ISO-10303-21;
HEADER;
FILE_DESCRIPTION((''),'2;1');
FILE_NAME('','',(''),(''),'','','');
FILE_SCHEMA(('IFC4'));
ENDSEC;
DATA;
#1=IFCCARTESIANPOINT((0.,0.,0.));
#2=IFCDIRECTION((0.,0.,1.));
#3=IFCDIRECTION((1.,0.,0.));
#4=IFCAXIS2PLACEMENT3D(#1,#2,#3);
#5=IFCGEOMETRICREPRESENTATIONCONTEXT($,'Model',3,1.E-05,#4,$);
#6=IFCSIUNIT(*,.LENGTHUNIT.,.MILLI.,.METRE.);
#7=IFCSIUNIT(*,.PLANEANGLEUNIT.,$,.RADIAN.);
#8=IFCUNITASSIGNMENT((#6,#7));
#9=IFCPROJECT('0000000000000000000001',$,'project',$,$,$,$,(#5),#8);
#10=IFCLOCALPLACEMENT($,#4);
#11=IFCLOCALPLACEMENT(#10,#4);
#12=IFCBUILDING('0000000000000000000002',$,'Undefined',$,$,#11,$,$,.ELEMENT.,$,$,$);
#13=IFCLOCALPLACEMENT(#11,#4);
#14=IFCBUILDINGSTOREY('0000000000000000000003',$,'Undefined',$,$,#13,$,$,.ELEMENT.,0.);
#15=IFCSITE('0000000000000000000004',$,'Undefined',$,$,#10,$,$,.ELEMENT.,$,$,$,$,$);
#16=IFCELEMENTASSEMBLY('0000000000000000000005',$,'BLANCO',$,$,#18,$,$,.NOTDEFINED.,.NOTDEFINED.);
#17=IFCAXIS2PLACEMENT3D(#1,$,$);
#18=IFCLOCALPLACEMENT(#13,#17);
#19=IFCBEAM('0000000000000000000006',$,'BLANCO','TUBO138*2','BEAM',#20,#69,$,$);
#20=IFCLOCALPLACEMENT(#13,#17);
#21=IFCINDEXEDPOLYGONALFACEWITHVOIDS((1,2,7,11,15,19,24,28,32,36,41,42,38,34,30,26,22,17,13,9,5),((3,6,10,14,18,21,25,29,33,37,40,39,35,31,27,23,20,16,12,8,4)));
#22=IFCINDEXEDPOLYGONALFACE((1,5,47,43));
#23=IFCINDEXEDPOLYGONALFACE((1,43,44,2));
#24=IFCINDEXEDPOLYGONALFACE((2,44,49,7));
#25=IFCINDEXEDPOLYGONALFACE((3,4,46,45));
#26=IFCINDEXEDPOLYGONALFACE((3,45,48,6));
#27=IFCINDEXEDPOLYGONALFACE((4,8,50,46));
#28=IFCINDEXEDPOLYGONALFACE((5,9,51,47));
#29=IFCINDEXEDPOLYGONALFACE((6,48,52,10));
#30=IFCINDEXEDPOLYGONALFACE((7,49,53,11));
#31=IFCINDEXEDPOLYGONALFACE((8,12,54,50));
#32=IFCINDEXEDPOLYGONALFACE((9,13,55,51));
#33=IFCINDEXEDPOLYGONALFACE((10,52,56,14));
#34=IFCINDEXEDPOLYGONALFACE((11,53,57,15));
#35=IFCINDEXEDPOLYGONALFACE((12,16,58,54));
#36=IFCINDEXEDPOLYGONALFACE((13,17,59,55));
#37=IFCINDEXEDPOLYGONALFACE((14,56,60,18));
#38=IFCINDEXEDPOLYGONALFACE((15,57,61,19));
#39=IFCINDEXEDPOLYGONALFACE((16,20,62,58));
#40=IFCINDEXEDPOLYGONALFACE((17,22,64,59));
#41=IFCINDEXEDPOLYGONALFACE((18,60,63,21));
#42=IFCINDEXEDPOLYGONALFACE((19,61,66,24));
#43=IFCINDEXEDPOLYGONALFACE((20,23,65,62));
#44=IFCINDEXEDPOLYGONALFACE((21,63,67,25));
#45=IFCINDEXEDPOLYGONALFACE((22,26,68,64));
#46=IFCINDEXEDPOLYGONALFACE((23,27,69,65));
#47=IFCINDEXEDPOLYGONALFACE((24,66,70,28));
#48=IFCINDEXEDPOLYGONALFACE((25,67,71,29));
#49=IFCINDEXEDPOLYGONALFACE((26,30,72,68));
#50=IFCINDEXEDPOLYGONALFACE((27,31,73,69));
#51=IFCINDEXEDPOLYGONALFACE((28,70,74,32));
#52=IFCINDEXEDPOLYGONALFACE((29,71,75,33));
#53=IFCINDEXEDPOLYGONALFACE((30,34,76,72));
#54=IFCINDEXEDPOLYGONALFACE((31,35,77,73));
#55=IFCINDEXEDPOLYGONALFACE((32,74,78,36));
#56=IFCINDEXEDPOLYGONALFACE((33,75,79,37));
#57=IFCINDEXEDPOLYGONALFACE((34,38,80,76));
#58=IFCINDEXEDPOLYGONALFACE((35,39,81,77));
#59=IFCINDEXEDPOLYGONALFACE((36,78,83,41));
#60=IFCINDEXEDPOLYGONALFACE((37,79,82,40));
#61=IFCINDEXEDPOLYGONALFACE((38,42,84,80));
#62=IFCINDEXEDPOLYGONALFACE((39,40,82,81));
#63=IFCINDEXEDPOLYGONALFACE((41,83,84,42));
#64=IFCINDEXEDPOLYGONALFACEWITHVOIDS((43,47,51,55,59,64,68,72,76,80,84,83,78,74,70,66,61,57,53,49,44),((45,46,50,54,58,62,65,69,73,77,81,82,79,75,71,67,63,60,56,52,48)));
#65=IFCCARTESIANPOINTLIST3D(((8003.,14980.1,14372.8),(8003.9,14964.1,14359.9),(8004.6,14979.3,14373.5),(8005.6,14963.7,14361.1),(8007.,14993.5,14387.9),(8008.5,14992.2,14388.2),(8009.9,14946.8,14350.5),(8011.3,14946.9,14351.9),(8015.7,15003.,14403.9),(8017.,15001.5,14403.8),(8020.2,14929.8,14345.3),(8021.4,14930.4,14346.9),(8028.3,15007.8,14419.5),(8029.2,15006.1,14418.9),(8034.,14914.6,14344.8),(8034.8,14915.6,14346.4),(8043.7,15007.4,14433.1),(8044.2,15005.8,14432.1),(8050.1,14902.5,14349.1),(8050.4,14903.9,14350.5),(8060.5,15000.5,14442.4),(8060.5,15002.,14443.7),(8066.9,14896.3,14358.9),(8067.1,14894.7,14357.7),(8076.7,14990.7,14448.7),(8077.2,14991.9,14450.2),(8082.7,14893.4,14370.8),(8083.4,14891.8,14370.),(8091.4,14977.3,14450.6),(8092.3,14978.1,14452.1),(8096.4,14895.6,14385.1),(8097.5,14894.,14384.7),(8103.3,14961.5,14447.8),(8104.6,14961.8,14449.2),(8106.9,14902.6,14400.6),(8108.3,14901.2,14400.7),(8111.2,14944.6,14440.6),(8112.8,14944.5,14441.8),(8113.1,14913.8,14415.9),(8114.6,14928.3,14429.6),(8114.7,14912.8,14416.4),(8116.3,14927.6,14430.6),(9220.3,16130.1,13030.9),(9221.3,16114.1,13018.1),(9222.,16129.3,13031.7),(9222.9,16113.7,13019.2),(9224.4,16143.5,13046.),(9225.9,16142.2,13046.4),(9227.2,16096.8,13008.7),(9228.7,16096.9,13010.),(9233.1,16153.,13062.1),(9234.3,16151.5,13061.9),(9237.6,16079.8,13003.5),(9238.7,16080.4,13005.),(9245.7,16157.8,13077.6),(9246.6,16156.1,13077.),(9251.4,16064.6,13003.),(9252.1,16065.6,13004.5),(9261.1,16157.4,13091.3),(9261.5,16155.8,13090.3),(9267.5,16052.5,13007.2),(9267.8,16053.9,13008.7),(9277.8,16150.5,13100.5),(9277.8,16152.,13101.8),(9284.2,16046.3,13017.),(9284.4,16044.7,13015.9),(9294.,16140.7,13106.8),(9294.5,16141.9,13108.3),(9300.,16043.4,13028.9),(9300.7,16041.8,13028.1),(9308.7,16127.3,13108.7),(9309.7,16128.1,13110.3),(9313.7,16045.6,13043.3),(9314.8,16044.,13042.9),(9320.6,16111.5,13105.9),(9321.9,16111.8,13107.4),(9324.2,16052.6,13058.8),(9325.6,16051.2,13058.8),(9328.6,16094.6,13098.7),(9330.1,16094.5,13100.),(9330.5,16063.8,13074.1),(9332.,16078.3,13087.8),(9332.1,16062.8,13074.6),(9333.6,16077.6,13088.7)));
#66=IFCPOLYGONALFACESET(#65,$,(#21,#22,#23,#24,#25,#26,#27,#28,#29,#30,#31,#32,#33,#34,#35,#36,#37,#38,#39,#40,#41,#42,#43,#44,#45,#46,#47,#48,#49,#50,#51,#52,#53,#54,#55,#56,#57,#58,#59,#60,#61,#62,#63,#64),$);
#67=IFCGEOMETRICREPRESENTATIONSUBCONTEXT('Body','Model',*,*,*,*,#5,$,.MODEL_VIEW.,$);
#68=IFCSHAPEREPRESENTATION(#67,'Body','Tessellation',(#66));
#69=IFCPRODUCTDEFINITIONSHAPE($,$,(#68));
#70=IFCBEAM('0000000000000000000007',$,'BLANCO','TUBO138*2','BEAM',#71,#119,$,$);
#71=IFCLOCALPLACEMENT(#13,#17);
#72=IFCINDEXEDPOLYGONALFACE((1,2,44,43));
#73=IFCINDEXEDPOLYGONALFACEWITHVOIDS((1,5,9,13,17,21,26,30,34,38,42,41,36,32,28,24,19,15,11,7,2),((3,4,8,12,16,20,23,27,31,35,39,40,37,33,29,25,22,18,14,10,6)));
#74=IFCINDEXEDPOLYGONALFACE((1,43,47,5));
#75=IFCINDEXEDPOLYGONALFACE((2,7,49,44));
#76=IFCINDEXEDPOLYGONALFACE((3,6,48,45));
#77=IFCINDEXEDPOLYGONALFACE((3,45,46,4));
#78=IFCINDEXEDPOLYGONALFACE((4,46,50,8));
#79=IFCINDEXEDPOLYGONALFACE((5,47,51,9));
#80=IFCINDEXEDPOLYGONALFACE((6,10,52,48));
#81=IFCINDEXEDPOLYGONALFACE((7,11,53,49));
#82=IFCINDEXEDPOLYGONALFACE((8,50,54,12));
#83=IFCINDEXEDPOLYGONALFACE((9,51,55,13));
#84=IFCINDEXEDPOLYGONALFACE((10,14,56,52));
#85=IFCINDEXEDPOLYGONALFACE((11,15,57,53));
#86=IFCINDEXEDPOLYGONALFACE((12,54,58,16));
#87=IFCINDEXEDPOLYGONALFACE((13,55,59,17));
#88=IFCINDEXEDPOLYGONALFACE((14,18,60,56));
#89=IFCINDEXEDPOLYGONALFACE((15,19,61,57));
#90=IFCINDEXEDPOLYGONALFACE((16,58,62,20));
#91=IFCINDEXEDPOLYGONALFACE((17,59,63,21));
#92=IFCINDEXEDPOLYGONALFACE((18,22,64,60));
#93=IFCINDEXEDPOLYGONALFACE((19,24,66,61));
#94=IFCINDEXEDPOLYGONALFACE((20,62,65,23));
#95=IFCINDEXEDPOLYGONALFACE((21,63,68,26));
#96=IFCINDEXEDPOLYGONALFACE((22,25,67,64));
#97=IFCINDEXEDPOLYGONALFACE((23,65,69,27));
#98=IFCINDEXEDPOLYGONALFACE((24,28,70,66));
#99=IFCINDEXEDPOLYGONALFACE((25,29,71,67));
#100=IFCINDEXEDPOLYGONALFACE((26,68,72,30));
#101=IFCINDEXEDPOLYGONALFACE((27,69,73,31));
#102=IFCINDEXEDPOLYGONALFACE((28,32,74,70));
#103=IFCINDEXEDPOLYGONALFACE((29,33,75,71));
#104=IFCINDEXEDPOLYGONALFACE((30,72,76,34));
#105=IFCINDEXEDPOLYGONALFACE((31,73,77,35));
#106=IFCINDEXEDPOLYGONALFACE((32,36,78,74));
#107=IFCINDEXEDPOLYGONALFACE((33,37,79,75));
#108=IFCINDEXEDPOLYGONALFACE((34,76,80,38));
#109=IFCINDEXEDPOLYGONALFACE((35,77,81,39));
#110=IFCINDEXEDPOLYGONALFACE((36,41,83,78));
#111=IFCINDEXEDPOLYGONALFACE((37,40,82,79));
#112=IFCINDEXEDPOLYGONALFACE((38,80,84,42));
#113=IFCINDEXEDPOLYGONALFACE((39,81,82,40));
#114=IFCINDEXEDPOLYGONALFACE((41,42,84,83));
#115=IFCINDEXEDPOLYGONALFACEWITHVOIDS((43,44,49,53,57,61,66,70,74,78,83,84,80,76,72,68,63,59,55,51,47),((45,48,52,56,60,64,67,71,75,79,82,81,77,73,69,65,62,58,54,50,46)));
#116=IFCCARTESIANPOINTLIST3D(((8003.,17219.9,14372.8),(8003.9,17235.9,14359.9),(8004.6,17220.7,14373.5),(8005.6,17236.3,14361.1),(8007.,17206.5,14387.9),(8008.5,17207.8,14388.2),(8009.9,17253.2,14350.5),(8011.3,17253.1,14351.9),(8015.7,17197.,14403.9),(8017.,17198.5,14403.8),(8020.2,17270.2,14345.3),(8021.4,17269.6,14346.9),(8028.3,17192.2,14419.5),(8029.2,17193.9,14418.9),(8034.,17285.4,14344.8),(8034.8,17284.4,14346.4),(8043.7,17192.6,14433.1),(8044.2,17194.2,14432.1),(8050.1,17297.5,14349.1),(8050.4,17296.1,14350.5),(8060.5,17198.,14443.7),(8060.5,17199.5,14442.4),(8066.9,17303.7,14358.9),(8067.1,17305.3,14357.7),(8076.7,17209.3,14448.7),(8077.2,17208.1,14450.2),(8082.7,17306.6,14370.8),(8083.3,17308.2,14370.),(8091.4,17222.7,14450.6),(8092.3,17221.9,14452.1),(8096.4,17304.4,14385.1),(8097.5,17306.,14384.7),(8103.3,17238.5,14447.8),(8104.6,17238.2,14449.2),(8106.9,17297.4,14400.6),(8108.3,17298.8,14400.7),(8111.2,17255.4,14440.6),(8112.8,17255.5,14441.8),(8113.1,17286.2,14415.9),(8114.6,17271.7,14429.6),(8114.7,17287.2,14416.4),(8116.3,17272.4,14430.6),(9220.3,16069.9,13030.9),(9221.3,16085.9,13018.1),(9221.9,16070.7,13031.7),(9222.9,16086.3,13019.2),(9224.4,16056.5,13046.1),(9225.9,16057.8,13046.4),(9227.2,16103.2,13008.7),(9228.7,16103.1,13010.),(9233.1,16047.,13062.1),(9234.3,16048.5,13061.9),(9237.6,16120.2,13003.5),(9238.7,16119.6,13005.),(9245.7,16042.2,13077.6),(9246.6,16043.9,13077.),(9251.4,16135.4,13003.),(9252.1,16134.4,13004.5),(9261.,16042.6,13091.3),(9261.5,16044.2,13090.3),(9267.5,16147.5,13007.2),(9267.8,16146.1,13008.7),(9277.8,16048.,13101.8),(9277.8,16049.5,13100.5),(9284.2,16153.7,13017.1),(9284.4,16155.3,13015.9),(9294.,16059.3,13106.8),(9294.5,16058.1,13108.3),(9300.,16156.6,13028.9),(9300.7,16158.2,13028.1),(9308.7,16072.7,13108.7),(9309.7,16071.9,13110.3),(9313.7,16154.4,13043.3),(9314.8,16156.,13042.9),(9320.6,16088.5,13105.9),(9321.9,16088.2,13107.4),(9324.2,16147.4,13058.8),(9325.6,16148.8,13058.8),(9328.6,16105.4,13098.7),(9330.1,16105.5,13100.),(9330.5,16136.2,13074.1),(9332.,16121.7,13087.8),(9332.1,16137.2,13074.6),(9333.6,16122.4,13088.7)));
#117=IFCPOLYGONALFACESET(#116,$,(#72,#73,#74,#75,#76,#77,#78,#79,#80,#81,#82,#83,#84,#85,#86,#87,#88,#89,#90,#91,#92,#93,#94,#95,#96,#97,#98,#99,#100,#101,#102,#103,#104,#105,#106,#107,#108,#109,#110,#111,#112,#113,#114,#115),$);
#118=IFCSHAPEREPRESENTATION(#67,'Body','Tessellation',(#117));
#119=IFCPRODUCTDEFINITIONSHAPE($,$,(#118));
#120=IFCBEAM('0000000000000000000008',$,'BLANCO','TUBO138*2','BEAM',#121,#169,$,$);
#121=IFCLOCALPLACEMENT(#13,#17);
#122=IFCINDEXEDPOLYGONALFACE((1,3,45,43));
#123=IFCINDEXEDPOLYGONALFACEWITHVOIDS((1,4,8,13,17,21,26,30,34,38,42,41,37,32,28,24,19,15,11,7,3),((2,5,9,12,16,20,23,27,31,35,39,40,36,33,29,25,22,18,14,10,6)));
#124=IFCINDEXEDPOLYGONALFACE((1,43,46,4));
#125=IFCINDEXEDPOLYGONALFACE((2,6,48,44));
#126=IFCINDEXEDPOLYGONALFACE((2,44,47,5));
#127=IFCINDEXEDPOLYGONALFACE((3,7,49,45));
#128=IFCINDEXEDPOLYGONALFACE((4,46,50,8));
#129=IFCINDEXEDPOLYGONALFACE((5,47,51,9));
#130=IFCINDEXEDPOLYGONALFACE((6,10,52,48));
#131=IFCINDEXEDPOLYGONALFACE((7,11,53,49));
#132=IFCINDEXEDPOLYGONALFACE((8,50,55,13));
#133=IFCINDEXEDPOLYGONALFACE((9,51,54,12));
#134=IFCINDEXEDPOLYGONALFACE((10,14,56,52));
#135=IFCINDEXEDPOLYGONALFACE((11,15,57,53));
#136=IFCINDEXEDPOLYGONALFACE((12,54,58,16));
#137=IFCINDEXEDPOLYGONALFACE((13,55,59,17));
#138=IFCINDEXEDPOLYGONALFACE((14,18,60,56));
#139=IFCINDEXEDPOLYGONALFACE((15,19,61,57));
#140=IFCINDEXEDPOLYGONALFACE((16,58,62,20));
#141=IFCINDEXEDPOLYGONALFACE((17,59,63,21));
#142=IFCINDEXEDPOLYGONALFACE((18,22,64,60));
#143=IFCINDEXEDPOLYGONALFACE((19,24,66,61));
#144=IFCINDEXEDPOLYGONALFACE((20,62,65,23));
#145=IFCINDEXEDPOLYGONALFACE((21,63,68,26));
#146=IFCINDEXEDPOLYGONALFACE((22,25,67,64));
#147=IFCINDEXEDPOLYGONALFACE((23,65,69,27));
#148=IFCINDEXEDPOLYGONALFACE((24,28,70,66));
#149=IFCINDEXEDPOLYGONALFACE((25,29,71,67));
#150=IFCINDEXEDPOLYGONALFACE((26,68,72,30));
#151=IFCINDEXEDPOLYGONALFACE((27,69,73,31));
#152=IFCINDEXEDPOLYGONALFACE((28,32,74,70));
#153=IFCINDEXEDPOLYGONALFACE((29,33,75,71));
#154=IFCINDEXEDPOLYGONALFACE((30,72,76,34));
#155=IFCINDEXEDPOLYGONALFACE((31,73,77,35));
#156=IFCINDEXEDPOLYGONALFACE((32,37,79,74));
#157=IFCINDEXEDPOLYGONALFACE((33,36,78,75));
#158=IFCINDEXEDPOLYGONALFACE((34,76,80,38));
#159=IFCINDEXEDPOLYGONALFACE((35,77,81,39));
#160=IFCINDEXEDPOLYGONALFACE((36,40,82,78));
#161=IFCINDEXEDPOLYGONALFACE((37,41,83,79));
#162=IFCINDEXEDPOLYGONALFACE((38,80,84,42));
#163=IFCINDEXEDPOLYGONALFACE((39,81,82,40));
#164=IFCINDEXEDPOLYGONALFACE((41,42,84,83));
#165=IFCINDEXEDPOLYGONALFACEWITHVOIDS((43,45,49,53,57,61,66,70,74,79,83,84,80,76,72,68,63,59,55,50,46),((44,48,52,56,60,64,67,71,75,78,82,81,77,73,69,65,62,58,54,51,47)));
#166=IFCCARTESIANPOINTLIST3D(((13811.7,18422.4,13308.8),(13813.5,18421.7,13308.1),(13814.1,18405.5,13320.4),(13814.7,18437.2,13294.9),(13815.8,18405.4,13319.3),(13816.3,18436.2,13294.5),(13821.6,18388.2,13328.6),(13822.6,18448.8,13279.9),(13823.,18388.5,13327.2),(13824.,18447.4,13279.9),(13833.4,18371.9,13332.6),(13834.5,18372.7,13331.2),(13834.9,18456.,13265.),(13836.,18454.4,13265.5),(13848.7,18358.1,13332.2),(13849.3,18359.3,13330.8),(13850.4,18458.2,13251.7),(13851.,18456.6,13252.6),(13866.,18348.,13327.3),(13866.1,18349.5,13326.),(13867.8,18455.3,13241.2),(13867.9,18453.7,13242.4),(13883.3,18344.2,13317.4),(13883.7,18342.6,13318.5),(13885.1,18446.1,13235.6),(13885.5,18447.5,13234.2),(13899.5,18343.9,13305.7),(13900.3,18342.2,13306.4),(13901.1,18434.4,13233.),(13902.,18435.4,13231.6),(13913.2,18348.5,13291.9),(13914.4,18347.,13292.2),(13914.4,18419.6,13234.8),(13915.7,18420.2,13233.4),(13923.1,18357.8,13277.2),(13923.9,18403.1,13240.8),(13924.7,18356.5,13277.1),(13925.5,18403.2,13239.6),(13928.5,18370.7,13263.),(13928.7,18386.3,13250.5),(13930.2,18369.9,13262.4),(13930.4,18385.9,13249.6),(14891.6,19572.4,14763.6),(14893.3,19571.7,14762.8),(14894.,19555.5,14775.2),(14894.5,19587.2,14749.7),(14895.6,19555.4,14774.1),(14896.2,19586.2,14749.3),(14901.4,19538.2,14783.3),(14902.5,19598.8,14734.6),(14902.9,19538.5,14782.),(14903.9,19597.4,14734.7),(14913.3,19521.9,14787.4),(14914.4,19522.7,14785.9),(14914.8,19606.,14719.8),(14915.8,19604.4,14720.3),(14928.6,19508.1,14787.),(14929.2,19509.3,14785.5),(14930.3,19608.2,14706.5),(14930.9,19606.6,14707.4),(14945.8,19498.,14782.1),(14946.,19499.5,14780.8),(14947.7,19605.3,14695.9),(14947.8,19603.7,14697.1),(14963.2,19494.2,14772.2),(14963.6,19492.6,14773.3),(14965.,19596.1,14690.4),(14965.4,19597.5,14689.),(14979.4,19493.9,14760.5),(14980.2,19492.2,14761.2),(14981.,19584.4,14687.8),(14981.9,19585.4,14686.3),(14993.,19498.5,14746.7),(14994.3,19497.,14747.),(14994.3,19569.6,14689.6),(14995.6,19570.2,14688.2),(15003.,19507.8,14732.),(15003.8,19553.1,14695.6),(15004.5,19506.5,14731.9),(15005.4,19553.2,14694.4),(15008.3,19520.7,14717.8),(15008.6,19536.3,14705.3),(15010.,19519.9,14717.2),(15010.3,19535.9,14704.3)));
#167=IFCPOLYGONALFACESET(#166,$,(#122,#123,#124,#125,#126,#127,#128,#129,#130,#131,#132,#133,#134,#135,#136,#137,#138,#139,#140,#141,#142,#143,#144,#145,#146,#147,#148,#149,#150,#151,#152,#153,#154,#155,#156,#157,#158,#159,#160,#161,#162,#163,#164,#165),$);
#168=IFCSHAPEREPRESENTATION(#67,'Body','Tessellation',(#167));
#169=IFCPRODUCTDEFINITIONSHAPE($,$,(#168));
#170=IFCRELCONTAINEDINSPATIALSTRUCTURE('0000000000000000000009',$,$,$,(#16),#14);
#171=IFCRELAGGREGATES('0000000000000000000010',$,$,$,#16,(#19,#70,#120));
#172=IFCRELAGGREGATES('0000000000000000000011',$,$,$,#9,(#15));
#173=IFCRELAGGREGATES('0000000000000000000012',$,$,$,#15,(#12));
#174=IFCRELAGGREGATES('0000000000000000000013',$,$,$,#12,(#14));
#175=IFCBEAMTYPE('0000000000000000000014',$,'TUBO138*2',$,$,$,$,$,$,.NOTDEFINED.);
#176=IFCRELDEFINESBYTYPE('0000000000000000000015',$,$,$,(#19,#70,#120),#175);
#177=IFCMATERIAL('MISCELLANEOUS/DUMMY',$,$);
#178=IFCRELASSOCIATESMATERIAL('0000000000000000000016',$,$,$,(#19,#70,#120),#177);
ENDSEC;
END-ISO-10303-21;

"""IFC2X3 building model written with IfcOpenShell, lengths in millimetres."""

from ifc_helpers import new_model, si_unit, frame, origin_with_axes, origin_2d_with_axis, place, context, subcontext, project, spatial, hollow_circle, extrude, material, type_object, element, aggregate, save


model = new_model("IFC2X3")

# Units and contexts
model_context = context("Model", 3, precision=1e-05, world=origin_with_axes())
body_context = subcontext(model_context, "Body", "Model", "MODEL_VIEW")
ifc_project = project(units=[si_unit("LENGTHUNIT", "METRE", prefix="MILLI"), si_unit("PLANEANGLEUNIT", "RADIAN")], contexts=[model_context])

# Site, building, storey
site_placement = place(None, origin_with_axes())
site = spatial("IfcSite", under=ifc_project, at=site_placement, Name="Undefined", CompositionType="ELEMENT")
building_placement = place(site_placement, origin_with_axes())
building = spatial("IfcBuilding", under=site, at=building_placement, Name="Undefined", CompositionType="ELEMENT")
storey_placement = place(building_placement, origin_with_axes())
storey = spatial("IfcBuildingStorey", under=building, at=storey_placement, Name="Undefined", CompositionType="ELEMENT", Elevation=0.0)

# Element assembly, beams
assembly_placement = place(storey_placement, origin_with_axes())
assembly = element("IfcElementAssembly", 1, at=assembly_placement, inside=storey, Name="BLANCO", AssemblyPlace="NOTDEFINED", PredefinedType="NOTDEFINED")
ifc_material = material(Name="MISCELLANEOUS/DUMMY")
beam_type = type_object("IfcBeamType", Name="TUBO138*2", PredefinedType="NOTDEFINED")
beam_1_placement = place(assembly_placement, frame((9276.9, 16100.0, 13056.4), z_axis=(-0.423552, -0.461316, -0.77961), x_axis=(-0.567282, -0.535899, 0.625303)))
beam_1 = element("IfcBeam", 2, at=beam_1_placement, type_object=beam_type, material=ifc_material, Name="BLANCO", Description="TUBO138*2", ObjectType="BEAM", context=body_context, shape_type="SweptSolid", body=[
    extrude(hollow_circle(Radius=69.0, WallThickness=2.0, at=origin_2d_with_axis()), frame((2145.9, 0.0, 0.0), z_axis=(-1.0, 0.0, 0.0), x_axis=(0.0, -1.0, 0.0)), (0.0, 0.0, 1.0), 2145.9),
])
beam_2_placement = place(assembly_placement, frame((8059.5, 17250.0, 14398.3), z_axis=(-0.423552, 0.461316, -0.77961), x_axis=(0.567282, -0.535899, -0.625303)))
beam_2 = element("IfcBeam", 3, at=beam_2_placement, type_object=beam_type, material=ifc_material, Name="BLANCO", Description="TUBO138*2", ObjectType="BEAM", context=body_context, shape_type="SweptSolid", body=[
    extrude(hollow_circle(Radius=69.0, WallThickness=2.0, at=origin_2d_with_axis()), frame((2145.9, 0.0, 0.0), z_axis=(-1.0, 0.0, 0.0), x_axis=(0.0, -1.0, 0.0)), (0.0, 0.0, 1.0), 2145.9),
])
beam_3_placement = place(assembly_placement, frame((13871.3, 18400.0, 13282.3), z_axis=(0.497966, 0.461316, -0.734314), x_axis=(0.503224, 0.535899, 0.677922)))
beam_3 = element("IfcBeam", 4, at=beam_3_placement, type_object=beam_type, material=ifc_material, Name="BLANCO", Description="TUBO138*2", ObjectType="BEAM", context=body_context, shape_type="SweptSolid", body=[
    extrude(hollow_circle(Radius=69.0, WallThickness=2.0, at=origin_2d_with_axis()), frame((2145.9, 0.0, 0.0), z_axis=(-1.0, 0.0, 0.0), x_axis=(0.0, -1.0, 0.0)), (0.0, 0.0, 1.0), 2145.9),
])
aggregate(assembly, [beam_1, beam_2, beam_3])

save(model, "model.ifc")
